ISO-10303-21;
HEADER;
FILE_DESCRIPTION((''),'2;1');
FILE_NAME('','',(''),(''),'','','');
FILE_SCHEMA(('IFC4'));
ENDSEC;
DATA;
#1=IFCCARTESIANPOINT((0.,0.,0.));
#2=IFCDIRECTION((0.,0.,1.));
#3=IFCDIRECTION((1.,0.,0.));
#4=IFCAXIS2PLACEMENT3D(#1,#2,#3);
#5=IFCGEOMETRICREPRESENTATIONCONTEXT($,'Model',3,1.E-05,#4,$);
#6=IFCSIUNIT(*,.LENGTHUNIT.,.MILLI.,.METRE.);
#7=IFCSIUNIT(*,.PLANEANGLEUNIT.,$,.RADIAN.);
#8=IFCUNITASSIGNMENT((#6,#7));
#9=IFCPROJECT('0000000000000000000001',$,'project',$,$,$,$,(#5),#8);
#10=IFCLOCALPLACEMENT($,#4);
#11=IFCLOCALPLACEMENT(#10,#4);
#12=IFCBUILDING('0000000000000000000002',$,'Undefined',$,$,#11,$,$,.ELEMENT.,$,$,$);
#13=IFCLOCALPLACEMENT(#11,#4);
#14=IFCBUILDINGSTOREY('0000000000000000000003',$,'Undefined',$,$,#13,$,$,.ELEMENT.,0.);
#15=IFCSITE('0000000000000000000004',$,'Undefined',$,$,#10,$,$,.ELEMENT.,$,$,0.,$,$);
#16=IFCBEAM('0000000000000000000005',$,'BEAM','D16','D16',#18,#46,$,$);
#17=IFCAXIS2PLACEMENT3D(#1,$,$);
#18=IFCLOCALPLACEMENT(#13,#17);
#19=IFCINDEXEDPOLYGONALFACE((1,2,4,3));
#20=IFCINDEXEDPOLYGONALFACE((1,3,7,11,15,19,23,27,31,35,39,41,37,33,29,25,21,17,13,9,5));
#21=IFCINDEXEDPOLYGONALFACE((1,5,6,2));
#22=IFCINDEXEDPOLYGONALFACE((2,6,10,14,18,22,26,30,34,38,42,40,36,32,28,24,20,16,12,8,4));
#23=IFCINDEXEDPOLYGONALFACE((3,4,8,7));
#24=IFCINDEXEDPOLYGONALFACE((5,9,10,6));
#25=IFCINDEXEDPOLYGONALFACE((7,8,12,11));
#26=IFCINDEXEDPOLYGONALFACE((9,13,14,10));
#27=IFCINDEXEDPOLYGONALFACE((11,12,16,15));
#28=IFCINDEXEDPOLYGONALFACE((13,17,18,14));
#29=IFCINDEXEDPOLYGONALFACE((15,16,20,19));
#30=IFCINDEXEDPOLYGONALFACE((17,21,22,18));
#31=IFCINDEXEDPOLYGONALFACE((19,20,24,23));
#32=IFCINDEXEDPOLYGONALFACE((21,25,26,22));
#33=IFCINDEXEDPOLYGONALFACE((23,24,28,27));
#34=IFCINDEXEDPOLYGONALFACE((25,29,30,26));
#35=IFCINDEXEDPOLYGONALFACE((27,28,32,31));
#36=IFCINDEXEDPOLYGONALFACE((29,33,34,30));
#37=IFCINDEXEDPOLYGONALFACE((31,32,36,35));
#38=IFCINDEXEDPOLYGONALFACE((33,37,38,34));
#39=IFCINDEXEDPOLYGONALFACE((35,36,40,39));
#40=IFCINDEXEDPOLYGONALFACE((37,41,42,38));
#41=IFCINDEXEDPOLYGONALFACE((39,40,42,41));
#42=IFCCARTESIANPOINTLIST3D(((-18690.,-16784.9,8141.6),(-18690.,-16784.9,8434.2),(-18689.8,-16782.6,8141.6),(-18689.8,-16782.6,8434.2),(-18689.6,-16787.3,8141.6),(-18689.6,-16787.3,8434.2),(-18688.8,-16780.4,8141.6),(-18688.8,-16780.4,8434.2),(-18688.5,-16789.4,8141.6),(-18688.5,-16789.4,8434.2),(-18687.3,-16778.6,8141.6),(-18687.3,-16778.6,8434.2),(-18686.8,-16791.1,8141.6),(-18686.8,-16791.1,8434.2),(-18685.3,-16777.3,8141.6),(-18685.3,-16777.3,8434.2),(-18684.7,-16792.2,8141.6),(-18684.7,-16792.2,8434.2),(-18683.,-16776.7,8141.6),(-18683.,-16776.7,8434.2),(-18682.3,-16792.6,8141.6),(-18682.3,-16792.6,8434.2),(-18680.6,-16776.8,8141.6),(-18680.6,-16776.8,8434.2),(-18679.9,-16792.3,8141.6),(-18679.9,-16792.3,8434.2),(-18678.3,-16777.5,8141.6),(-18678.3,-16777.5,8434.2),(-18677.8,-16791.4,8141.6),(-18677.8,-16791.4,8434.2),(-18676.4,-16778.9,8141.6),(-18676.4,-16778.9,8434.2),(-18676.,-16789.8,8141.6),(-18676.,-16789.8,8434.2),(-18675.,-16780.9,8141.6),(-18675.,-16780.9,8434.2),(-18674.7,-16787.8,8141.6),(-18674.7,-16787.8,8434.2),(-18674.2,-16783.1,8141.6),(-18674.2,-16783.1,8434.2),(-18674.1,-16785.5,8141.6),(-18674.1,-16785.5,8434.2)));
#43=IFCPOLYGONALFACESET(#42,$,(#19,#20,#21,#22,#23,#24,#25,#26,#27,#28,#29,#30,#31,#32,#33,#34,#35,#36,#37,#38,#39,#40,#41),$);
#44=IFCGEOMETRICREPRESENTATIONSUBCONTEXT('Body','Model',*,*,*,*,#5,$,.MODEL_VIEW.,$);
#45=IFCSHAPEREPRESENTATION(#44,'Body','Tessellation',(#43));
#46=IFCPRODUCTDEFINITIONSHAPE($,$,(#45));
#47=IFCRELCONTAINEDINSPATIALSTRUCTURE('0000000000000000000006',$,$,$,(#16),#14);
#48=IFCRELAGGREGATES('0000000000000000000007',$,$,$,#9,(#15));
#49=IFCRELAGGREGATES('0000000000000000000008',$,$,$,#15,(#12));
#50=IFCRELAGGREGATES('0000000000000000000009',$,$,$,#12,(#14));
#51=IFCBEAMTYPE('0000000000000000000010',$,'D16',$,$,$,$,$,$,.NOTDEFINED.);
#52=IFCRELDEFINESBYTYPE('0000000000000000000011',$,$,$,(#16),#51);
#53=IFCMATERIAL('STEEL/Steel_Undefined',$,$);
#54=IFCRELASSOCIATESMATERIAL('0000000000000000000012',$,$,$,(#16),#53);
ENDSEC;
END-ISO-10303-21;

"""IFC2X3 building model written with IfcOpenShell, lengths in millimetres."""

from ifc_helpers import new_model, si_unit, frame, origin_with_axes, origin_2d_with_axis, place, context, subcontext, project, spatial, circle, extrude, material, type_object, element, save


model = new_model("IFC2X3")

# Units and contexts
model_context = context("Model", 3, precision=1e-05, world=origin_with_axes())
body_context = subcontext(model_context, "Body", "Model", "MODEL_VIEW")
ifc_project = project(units=[si_unit("LENGTHUNIT", "METRE", prefix="MILLI"), si_unit("PLANEANGLEUNIT", "RADIAN")], contexts=[model_context])

# Site, building, storey
site_placement = place(None, origin_with_axes())
site = spatial("IfcSite", under=ifc_project, at=site_placement, Name="Undefined", CompositionType="ELEMENT", RefElevation=0.0)
building_placement = place(site_placement, origin_with_axes())
building = spatial("IfcBuilding", under=site, at=building_placement, Name="Undefined", CompositionType="ELEMENT")
storey_placement = place(building_placement, origin_with_axes())
storey = spatial("IfcBuildingStorey", under=building, at=storey_placement, Name="Undefined", CompositionType="ELEMENT", Elevation=0.0)

# Shared definitions
ifc_material_1 = material(Name="STEEL/Steel_Undefined")

# Beam
beam_type_1 = type_object("IfcBeamType", Name="D16", PredefinedType="NOTDEFINED")
beam_1_placement = place(storey_placement, frame((-18682.0, -16784.6, 8434.2), z_axis=(-0.915553, -0.402197, 0.0), x_axis=(0.0, 0.0, -1.0)))
element("IfcBeam", 1, at=beam_1_placement, inside=storey, type_object=beam_type_1, material=ifc_material_1, Name="BEAM", Description="D16", ObjectType="D16", context=body_context, shape_type="SweptSolid", body=[
    extrude(circle(Radius=8.0, at=origin_2d_with_axis()), frame((292.6, 0.0, 0.0), z_axis=(-1.0, 0.0, 0.0), x_axis=(0.0, -1.0, 0.0)), (0.0, 0.0, 1.0), 292.6),
])

save(model, "model.ifc")
